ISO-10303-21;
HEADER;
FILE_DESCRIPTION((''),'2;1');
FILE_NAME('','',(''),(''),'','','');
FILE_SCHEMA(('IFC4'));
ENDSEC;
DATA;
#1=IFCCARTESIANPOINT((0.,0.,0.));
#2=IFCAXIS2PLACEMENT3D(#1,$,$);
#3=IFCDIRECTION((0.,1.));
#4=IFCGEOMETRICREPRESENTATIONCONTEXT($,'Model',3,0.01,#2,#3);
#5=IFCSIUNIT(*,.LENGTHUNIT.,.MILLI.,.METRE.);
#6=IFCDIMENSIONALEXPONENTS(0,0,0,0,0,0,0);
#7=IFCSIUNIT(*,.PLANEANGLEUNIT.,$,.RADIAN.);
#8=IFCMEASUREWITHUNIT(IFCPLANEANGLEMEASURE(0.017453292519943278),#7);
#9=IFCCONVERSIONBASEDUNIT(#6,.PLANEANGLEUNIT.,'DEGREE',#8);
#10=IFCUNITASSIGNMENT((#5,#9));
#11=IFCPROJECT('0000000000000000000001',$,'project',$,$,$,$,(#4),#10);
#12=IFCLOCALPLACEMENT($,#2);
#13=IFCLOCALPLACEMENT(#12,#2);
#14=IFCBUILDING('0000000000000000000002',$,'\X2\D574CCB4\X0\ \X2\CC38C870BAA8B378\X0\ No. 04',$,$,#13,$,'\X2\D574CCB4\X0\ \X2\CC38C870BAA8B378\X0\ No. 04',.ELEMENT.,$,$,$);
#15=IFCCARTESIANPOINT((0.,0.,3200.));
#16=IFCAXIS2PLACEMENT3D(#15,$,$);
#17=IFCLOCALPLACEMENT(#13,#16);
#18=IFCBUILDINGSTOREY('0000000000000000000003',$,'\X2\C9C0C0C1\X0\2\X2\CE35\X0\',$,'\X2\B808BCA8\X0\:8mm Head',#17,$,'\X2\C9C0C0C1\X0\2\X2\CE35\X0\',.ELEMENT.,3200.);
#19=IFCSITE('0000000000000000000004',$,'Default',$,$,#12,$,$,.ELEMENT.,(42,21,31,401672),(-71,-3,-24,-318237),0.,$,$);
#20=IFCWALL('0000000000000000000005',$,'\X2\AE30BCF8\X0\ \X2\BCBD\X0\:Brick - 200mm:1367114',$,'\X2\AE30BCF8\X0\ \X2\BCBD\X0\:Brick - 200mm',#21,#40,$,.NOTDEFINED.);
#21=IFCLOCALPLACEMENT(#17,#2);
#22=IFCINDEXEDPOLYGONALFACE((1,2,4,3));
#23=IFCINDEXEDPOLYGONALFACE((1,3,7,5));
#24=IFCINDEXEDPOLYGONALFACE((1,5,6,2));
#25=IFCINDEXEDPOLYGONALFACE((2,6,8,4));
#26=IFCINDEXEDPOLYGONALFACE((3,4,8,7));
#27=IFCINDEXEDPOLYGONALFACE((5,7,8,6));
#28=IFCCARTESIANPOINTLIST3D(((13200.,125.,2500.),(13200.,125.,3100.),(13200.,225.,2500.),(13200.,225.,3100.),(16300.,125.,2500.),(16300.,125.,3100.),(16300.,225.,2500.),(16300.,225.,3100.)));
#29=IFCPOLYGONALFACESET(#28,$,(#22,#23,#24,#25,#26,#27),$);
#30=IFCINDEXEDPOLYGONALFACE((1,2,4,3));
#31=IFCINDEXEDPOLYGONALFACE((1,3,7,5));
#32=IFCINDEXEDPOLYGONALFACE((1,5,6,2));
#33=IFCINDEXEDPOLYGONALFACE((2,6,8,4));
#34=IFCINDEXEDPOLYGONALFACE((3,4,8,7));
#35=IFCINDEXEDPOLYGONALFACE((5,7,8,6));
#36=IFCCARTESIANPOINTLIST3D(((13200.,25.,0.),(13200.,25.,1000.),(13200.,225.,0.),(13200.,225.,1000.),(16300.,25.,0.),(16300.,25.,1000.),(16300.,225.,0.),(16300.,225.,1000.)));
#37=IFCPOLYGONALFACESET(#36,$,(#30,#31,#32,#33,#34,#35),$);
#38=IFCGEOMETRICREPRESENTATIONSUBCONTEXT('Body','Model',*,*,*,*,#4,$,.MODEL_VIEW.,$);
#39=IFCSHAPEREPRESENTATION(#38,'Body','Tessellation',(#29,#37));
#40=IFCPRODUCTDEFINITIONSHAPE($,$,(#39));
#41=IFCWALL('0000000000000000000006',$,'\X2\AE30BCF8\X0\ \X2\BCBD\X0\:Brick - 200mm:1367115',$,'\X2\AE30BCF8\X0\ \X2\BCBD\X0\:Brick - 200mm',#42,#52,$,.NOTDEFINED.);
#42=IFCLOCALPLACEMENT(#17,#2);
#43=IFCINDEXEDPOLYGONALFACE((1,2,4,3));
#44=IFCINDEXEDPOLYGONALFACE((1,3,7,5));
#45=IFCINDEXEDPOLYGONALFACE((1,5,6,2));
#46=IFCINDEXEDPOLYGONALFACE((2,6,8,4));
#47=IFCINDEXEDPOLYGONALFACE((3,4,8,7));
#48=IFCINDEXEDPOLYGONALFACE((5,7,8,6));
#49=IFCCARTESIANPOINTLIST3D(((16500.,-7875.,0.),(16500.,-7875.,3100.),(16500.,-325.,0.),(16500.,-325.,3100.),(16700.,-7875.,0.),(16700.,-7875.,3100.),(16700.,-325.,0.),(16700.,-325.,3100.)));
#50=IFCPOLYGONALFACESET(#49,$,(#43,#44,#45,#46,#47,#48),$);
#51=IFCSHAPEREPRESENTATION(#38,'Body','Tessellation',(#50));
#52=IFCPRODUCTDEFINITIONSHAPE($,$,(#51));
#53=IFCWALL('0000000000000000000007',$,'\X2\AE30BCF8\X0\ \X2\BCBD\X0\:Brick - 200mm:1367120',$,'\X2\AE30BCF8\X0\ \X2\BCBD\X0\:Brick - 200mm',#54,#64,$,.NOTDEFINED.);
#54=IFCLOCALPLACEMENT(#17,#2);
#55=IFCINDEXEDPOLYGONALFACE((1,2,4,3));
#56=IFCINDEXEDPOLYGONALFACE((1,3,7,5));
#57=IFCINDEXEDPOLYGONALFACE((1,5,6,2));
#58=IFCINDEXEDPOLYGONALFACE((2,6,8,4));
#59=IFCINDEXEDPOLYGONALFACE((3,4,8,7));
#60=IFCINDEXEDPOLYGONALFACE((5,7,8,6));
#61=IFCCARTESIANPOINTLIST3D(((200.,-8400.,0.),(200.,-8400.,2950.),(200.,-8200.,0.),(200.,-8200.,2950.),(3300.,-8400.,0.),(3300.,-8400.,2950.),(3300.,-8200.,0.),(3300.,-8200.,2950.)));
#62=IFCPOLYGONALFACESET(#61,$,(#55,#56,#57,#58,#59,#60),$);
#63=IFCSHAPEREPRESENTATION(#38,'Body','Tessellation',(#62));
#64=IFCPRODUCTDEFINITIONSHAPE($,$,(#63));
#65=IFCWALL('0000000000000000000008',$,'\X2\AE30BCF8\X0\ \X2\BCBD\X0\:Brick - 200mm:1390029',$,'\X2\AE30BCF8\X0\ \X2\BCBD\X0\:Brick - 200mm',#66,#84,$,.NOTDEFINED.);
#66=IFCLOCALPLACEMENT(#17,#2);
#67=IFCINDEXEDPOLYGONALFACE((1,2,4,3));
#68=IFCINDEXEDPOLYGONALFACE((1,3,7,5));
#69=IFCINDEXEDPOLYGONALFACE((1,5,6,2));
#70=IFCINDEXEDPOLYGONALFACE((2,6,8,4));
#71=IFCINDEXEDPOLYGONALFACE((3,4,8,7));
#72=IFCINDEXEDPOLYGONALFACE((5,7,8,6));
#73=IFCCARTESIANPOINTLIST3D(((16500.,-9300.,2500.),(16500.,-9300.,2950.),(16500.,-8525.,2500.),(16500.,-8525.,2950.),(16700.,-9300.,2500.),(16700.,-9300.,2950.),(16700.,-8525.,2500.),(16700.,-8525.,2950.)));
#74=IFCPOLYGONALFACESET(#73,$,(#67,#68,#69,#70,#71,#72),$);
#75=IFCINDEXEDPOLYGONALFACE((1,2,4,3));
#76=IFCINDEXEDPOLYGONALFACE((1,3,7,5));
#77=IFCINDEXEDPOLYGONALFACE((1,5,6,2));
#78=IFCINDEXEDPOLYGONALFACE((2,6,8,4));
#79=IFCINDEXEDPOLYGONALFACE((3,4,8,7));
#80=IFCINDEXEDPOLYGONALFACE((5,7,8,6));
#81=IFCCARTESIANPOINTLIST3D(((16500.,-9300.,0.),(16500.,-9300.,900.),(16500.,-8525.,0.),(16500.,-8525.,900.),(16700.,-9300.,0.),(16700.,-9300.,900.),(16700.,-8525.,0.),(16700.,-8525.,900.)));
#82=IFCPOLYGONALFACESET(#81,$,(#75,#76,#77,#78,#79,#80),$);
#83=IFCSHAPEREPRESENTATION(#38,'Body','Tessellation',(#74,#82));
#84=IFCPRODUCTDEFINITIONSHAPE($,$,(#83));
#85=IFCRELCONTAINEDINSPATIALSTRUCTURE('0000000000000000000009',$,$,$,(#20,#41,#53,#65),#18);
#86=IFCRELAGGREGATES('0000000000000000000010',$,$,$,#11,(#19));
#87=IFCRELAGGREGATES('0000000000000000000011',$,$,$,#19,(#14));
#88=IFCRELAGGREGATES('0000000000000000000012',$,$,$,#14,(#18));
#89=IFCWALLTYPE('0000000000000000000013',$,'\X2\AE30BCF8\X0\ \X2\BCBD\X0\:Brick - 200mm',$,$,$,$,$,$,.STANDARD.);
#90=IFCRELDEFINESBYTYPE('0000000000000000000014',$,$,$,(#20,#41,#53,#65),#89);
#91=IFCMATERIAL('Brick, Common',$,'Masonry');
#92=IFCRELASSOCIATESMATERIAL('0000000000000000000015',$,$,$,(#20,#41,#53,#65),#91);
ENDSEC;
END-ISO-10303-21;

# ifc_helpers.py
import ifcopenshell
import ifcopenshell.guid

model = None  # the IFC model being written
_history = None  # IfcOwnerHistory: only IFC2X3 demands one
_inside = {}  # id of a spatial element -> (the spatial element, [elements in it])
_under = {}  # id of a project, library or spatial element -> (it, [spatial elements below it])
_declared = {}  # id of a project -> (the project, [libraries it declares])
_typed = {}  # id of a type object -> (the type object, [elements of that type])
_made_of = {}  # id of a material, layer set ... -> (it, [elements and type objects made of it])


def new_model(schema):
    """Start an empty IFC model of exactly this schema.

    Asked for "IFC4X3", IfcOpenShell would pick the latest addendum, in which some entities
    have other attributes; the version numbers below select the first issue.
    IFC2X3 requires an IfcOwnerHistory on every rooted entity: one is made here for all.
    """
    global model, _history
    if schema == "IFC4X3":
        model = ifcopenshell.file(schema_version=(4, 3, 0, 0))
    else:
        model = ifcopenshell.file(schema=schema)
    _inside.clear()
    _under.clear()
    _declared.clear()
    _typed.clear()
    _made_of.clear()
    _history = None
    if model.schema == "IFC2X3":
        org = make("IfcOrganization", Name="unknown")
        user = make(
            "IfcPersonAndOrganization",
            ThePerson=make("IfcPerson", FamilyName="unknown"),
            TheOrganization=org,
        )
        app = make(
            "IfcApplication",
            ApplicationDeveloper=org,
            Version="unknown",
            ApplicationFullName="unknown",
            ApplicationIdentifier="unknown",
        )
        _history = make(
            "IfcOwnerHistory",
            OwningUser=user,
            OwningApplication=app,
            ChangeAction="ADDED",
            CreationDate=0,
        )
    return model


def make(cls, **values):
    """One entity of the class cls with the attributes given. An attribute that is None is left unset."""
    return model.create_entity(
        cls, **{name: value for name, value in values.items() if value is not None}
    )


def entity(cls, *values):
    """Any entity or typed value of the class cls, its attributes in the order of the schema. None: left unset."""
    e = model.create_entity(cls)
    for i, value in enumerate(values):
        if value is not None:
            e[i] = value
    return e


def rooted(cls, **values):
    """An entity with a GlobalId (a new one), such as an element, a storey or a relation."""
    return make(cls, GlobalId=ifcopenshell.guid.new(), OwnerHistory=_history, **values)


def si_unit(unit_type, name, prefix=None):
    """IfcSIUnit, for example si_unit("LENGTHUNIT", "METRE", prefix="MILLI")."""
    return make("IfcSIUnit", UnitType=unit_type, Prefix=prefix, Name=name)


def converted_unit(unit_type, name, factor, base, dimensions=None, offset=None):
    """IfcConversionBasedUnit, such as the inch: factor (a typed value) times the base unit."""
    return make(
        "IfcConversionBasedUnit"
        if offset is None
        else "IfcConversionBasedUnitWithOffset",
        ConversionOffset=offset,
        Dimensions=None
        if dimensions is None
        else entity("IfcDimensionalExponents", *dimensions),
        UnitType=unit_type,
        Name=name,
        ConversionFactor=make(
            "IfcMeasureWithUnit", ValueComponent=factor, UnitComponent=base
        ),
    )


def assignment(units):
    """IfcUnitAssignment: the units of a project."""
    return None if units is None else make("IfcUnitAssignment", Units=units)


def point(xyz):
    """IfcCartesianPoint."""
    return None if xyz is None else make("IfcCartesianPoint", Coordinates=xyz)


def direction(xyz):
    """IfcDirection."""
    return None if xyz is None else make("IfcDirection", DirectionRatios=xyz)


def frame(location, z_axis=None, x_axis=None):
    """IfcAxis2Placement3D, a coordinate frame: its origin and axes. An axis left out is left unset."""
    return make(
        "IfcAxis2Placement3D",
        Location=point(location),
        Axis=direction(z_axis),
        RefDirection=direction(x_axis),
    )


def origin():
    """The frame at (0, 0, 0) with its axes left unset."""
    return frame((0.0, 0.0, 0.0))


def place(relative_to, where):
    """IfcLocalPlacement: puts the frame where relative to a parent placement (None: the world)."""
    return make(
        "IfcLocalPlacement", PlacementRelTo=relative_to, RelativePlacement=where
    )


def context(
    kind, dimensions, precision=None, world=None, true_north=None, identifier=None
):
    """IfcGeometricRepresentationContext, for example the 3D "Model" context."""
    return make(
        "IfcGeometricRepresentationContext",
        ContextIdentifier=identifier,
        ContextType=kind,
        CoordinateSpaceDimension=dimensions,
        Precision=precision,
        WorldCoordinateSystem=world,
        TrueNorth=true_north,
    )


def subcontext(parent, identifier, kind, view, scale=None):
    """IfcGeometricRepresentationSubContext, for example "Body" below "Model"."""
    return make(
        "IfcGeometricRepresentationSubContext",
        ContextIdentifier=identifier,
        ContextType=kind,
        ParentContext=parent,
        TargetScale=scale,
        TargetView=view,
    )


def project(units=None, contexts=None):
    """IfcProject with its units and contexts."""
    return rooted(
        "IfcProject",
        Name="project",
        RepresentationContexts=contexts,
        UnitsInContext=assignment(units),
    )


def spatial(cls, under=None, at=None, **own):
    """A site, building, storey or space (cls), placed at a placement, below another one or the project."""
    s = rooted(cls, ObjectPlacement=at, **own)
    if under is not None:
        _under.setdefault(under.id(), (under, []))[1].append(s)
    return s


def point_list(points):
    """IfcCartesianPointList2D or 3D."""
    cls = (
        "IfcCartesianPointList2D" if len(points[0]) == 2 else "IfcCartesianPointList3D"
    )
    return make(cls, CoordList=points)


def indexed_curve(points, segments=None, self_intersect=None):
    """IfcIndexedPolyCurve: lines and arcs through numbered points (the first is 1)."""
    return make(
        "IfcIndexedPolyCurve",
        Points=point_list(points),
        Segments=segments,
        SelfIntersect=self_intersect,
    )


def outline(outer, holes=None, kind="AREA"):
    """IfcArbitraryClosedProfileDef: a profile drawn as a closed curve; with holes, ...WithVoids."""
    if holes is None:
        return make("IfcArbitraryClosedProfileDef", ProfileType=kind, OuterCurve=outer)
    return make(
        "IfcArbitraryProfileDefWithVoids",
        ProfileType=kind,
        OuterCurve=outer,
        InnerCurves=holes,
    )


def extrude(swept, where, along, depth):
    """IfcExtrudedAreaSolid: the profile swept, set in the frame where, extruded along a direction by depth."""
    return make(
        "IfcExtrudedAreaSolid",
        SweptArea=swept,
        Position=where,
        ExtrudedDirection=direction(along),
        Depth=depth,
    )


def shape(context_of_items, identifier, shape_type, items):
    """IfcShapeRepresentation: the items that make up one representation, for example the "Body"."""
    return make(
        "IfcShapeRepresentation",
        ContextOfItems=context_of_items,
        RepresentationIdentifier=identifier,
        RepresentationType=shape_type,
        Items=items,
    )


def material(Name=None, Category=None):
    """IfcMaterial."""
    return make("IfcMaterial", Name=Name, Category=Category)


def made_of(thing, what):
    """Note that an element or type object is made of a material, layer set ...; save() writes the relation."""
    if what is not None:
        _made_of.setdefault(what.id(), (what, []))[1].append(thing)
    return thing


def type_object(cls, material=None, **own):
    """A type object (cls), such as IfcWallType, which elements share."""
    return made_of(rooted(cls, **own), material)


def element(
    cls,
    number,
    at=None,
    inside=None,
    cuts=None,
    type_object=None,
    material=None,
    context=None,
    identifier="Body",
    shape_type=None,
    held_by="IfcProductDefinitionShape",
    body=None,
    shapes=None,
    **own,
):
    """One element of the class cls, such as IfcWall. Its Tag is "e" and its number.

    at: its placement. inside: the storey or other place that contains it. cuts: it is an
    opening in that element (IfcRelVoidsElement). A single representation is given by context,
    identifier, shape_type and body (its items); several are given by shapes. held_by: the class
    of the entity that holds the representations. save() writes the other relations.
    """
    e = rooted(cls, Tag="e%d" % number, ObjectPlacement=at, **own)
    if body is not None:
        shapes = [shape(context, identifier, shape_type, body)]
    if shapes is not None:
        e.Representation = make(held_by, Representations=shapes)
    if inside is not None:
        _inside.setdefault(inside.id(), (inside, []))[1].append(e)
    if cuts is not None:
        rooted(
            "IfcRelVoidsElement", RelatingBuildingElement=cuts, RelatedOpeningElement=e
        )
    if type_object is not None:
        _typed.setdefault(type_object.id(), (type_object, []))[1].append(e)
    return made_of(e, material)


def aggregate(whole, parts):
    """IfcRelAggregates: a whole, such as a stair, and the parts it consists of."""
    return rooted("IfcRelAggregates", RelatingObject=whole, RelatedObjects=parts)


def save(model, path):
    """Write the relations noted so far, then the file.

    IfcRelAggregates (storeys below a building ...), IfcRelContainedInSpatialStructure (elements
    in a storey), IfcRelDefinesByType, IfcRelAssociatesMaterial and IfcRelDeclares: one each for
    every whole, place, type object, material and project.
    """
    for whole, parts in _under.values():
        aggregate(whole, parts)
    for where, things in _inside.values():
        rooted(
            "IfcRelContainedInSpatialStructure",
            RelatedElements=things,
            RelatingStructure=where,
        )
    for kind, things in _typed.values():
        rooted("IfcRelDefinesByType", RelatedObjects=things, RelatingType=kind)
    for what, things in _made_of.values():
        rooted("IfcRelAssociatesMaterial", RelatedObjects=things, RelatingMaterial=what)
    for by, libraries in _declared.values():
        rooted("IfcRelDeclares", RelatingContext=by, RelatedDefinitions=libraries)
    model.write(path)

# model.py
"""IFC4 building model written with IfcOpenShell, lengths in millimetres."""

from ifc_helpers import new_model, entity, si_unit, converted_unit, direction, frame, origin, place, context, subcontext, project, spatial, indexed_curve, outline, extrude, material, type_object, element, save


model = new_model("IFC4")

# Units and contexts
model_context = context("Model", 3, precision=0.01, world=origin(), true_north=direction((0.0, 1.0)))
body_context = subcontext(model_context, "Body", "Model", "MODEL_VIEW")
ifc_project = project(units=[si_unit("LENGTHUNIT", "METRE", prefix="MILLI"), converted_unit("PLANEANGLEUNIT", "DEGREE", entity("IfcPlaneAngleMeasure", 0.017453292519943278), si_unit("PLANEANGLEUNIT", "RADIAN"), dimensions=[0, 0, 0, 0, 0, 0, 0])], contexts=[model_context])

# Site, building, storey
site_placement = place(None, origin())
site = spatial("IfcSite", under=ifc_project, at=site_placement, Name="Default", CompositionType="ELEMENT", RefLatitude=(42, 21, 31, 401672), RefLongitude=(-71, -3, -24, -318237), RefElevation=0.0)
building_placement = place(site_placement, origin())
building = spatial("IfcBuilding", under=site, at=building_placement, Name="해체 참조모델 No. 04", LongName="해체 참조모델 No. 04", CompositionType="ELEMENT")
storey_placement = place(building_placement, frame((0.0, 0.0, 3200.0)))
storey = spatial("IfcBuildingStorey", under=building, at=storey_placement, Name="지상2층", ObjectType="레벨:8mm Head", LongName="지상2층", CompositionType="ELEMENT", Elevation=3200.0)

# Shared definitions
ifc_material_1 = material(Name="Brick, Common", Category="Masonry")
wall_type = type_object("IfcWallType", Name="기본 벽:Brick - 200mm", PredefinedType="STANDARD")

# Wall, opening
wall_1_placement = place(storey_placement, frame((13200.0, 125.0, 0.0)))
wall_1 = element("IfcWall", 1, at=wall_1_placement, inside=storey, type_object=wall_type, material=ifc_material_1, Name="기본 벽:Brick - 200mm:1367114", ObjectType="기본 벽:Brick - 200mm", PredefinedType="NOTDEFINED", context=body_context, shape_type="SweptSolid", body=[
    extrude(outline(indexed_curve([(-50.0, -1550.0), (50.0, -1550.0), (50.0, 1550.0), (-50.0, 1550.0), (-50.0, -1550.0)], self_intersect=False)), frame((1550.0, 50.0, 2500.0), z_axis=(0.0, 0.0, 1.0), x_axis=(0.0, -1.0, 0.0)), (0.0, 0.0, 1.0), 600.0),
    extrude(outline(indexed_curve([(-100.0, -1550.0), (0.0, -1550.0), (100.0, -1550.0), (100.0, 1550.0), (0.0, 1550.0), (-100.0, 1550.0), (-100.0, -1550.0)], self_intersect=False)), frame((1550.0, 0.0, 0.0), z_axis=(0.0, 0.0, 1.0), x_axis=(0.0, 1.0, 0.0)), (0.0, 0.0, 1.0), 1000.0),
])
opening_1_placement = place(wall_1_placement, origin())
element("IfcOpeningElement", 2, at=opening_1_placement, cuts=wall_1, PredefinedType="OPENING", context=body_context, shape_type="SweptSolid", body=[
    extrude(outline(indexed_curve([(-750.0, -1550.0), (750.0, -1550.0), (750.0, 1550.0), (-750.0, 1550.0), (-750.0, -1550.0)], self_intersect=False)), frame((1550.0, -252.4, 1750.0), z_axis=(0.0, 1.0, 0.0), x_axis=(0.0, 0.0, 1.0)), (0.0, 0.0, 1.0), 504.8),
])

# Walls
wall_2_placement = place(storey_placement, frame((16600.0, -325.0, 0.0), z_axis=(0.0, 0.0, 1.0), x_axis=(0.0, -1.0, 0.0)))
element("IfcWall", 3, at=wall_2_placement, inside=storey, type_object=wall_type, material=ifc_material_1, Name="기본 벽:Brick - 200mm:1367115", ObjectType="기본 벽:Brick - 200mm", PredefinedType="NOTDEFINED", context=body_context, shape_type="SweptSolid", body=[
    extrude(outline(indexed_curve([(7550.0, 100.0), (0.0, 100.0), (0.0, -100.0), (7550.0, -100.0), (7550.0, 100.0)], self_intersect=False)), origin(), (0.0, 0.0, 1.0), 3100.0),
])
wall_3_placement = place(storey_placement, frame((3300.0, -8300.0, 0.0), z_axis=(0.0, 0.0, 1.0), x_axis=(-1.0, 0.0, 0.0)))
element("IfcWall", 4, at=wall_3_placement, inside=storey, type_object=wall_type, material=ifc_material_1, Name="기본 벽:Brick - 200mm:1367120", ObjectType="기본 벽:Brick - 200mm", PredefinedType="NOTDEFINED", context=body_context, shape_type="SweptSolid", body=[
    extrude(outline(indexed_curve([(3100.0, 100.0), (0.0, 100.0), (0.0, -100.0), (3100.0, -100.0), (3100.0, 100.0)], self_intersect=False)), origin(), (0.0, 0.0, 1.0), 2950.0),
])

# Wall, opening
wall_4_placement = place(storey_placement, frame((16600.0, -9300.0, 0.0), z_axis=(0.0, 0.0, 1.0), x_axis=(0.0, 1.0, 0.0)))
wall_4 = element("IfcWall", 5, at=wall_4_placement, inside=storey, type_object=wall_type, material=ifc_material_1, Name="기본 벽:Brick - 200mm:1390029", ObjectType="기본 벽:Brick - 200mm", PredefinedType="NOTDEFINED", context=body_context, shape_type="SweptSolid", body=[
    extrude(outline(indexed_curve([(-100.0, -387.5), (100.0, -387.5), (100.0, 387.5), (-100.0, 387.5), (-100.0, -387.5)], self_intersect=False)), frame((387.5, 0.0, 2500.0), z_axis=(0.0, 0.0, 1.0), x_axis=(0.0, 1.0, 0.0)), (0.0, 0.0, 1.0), 450.0),
    extrude(outline(indexed_curve([(-100.0, -387.5), (100.0, -387.5), (100.0, 387.5), (-100.0, 387.5), (-100.0, -387.5)], self_intersect=False)), frame((387.5, 0.0, 0.0), z_axis=(0.0, 0.0, 1.0), x_axis=(0.0, 1.0, 0.0)), (0.0, 0.0, 1.0), 900.0),
])
opening_2_placement = place(wall_4_placement, origin())
element("IfcOpeningElement", 6, at=opening_2_placement, cuts=wall_4, PredefinedType="OPENING", context=body_context, shape_type="SweptSolid", body=[
    extrude(outline(indexed_curve([(-800.0, -387.5), (800.0, -387.5), (800.0, 387.5), (-800.0, 387.5), (-800.0, -387.5)], self_intersect=False)), frame((387.5, -252.4, 1700.0), z_axis=(0.0, 1.0, 0.0), x_axis=(0.0, 0.0, 1.0)), (0.0, 0.0, 1.0), 504.8),
])

save(model, "model.ifc")
